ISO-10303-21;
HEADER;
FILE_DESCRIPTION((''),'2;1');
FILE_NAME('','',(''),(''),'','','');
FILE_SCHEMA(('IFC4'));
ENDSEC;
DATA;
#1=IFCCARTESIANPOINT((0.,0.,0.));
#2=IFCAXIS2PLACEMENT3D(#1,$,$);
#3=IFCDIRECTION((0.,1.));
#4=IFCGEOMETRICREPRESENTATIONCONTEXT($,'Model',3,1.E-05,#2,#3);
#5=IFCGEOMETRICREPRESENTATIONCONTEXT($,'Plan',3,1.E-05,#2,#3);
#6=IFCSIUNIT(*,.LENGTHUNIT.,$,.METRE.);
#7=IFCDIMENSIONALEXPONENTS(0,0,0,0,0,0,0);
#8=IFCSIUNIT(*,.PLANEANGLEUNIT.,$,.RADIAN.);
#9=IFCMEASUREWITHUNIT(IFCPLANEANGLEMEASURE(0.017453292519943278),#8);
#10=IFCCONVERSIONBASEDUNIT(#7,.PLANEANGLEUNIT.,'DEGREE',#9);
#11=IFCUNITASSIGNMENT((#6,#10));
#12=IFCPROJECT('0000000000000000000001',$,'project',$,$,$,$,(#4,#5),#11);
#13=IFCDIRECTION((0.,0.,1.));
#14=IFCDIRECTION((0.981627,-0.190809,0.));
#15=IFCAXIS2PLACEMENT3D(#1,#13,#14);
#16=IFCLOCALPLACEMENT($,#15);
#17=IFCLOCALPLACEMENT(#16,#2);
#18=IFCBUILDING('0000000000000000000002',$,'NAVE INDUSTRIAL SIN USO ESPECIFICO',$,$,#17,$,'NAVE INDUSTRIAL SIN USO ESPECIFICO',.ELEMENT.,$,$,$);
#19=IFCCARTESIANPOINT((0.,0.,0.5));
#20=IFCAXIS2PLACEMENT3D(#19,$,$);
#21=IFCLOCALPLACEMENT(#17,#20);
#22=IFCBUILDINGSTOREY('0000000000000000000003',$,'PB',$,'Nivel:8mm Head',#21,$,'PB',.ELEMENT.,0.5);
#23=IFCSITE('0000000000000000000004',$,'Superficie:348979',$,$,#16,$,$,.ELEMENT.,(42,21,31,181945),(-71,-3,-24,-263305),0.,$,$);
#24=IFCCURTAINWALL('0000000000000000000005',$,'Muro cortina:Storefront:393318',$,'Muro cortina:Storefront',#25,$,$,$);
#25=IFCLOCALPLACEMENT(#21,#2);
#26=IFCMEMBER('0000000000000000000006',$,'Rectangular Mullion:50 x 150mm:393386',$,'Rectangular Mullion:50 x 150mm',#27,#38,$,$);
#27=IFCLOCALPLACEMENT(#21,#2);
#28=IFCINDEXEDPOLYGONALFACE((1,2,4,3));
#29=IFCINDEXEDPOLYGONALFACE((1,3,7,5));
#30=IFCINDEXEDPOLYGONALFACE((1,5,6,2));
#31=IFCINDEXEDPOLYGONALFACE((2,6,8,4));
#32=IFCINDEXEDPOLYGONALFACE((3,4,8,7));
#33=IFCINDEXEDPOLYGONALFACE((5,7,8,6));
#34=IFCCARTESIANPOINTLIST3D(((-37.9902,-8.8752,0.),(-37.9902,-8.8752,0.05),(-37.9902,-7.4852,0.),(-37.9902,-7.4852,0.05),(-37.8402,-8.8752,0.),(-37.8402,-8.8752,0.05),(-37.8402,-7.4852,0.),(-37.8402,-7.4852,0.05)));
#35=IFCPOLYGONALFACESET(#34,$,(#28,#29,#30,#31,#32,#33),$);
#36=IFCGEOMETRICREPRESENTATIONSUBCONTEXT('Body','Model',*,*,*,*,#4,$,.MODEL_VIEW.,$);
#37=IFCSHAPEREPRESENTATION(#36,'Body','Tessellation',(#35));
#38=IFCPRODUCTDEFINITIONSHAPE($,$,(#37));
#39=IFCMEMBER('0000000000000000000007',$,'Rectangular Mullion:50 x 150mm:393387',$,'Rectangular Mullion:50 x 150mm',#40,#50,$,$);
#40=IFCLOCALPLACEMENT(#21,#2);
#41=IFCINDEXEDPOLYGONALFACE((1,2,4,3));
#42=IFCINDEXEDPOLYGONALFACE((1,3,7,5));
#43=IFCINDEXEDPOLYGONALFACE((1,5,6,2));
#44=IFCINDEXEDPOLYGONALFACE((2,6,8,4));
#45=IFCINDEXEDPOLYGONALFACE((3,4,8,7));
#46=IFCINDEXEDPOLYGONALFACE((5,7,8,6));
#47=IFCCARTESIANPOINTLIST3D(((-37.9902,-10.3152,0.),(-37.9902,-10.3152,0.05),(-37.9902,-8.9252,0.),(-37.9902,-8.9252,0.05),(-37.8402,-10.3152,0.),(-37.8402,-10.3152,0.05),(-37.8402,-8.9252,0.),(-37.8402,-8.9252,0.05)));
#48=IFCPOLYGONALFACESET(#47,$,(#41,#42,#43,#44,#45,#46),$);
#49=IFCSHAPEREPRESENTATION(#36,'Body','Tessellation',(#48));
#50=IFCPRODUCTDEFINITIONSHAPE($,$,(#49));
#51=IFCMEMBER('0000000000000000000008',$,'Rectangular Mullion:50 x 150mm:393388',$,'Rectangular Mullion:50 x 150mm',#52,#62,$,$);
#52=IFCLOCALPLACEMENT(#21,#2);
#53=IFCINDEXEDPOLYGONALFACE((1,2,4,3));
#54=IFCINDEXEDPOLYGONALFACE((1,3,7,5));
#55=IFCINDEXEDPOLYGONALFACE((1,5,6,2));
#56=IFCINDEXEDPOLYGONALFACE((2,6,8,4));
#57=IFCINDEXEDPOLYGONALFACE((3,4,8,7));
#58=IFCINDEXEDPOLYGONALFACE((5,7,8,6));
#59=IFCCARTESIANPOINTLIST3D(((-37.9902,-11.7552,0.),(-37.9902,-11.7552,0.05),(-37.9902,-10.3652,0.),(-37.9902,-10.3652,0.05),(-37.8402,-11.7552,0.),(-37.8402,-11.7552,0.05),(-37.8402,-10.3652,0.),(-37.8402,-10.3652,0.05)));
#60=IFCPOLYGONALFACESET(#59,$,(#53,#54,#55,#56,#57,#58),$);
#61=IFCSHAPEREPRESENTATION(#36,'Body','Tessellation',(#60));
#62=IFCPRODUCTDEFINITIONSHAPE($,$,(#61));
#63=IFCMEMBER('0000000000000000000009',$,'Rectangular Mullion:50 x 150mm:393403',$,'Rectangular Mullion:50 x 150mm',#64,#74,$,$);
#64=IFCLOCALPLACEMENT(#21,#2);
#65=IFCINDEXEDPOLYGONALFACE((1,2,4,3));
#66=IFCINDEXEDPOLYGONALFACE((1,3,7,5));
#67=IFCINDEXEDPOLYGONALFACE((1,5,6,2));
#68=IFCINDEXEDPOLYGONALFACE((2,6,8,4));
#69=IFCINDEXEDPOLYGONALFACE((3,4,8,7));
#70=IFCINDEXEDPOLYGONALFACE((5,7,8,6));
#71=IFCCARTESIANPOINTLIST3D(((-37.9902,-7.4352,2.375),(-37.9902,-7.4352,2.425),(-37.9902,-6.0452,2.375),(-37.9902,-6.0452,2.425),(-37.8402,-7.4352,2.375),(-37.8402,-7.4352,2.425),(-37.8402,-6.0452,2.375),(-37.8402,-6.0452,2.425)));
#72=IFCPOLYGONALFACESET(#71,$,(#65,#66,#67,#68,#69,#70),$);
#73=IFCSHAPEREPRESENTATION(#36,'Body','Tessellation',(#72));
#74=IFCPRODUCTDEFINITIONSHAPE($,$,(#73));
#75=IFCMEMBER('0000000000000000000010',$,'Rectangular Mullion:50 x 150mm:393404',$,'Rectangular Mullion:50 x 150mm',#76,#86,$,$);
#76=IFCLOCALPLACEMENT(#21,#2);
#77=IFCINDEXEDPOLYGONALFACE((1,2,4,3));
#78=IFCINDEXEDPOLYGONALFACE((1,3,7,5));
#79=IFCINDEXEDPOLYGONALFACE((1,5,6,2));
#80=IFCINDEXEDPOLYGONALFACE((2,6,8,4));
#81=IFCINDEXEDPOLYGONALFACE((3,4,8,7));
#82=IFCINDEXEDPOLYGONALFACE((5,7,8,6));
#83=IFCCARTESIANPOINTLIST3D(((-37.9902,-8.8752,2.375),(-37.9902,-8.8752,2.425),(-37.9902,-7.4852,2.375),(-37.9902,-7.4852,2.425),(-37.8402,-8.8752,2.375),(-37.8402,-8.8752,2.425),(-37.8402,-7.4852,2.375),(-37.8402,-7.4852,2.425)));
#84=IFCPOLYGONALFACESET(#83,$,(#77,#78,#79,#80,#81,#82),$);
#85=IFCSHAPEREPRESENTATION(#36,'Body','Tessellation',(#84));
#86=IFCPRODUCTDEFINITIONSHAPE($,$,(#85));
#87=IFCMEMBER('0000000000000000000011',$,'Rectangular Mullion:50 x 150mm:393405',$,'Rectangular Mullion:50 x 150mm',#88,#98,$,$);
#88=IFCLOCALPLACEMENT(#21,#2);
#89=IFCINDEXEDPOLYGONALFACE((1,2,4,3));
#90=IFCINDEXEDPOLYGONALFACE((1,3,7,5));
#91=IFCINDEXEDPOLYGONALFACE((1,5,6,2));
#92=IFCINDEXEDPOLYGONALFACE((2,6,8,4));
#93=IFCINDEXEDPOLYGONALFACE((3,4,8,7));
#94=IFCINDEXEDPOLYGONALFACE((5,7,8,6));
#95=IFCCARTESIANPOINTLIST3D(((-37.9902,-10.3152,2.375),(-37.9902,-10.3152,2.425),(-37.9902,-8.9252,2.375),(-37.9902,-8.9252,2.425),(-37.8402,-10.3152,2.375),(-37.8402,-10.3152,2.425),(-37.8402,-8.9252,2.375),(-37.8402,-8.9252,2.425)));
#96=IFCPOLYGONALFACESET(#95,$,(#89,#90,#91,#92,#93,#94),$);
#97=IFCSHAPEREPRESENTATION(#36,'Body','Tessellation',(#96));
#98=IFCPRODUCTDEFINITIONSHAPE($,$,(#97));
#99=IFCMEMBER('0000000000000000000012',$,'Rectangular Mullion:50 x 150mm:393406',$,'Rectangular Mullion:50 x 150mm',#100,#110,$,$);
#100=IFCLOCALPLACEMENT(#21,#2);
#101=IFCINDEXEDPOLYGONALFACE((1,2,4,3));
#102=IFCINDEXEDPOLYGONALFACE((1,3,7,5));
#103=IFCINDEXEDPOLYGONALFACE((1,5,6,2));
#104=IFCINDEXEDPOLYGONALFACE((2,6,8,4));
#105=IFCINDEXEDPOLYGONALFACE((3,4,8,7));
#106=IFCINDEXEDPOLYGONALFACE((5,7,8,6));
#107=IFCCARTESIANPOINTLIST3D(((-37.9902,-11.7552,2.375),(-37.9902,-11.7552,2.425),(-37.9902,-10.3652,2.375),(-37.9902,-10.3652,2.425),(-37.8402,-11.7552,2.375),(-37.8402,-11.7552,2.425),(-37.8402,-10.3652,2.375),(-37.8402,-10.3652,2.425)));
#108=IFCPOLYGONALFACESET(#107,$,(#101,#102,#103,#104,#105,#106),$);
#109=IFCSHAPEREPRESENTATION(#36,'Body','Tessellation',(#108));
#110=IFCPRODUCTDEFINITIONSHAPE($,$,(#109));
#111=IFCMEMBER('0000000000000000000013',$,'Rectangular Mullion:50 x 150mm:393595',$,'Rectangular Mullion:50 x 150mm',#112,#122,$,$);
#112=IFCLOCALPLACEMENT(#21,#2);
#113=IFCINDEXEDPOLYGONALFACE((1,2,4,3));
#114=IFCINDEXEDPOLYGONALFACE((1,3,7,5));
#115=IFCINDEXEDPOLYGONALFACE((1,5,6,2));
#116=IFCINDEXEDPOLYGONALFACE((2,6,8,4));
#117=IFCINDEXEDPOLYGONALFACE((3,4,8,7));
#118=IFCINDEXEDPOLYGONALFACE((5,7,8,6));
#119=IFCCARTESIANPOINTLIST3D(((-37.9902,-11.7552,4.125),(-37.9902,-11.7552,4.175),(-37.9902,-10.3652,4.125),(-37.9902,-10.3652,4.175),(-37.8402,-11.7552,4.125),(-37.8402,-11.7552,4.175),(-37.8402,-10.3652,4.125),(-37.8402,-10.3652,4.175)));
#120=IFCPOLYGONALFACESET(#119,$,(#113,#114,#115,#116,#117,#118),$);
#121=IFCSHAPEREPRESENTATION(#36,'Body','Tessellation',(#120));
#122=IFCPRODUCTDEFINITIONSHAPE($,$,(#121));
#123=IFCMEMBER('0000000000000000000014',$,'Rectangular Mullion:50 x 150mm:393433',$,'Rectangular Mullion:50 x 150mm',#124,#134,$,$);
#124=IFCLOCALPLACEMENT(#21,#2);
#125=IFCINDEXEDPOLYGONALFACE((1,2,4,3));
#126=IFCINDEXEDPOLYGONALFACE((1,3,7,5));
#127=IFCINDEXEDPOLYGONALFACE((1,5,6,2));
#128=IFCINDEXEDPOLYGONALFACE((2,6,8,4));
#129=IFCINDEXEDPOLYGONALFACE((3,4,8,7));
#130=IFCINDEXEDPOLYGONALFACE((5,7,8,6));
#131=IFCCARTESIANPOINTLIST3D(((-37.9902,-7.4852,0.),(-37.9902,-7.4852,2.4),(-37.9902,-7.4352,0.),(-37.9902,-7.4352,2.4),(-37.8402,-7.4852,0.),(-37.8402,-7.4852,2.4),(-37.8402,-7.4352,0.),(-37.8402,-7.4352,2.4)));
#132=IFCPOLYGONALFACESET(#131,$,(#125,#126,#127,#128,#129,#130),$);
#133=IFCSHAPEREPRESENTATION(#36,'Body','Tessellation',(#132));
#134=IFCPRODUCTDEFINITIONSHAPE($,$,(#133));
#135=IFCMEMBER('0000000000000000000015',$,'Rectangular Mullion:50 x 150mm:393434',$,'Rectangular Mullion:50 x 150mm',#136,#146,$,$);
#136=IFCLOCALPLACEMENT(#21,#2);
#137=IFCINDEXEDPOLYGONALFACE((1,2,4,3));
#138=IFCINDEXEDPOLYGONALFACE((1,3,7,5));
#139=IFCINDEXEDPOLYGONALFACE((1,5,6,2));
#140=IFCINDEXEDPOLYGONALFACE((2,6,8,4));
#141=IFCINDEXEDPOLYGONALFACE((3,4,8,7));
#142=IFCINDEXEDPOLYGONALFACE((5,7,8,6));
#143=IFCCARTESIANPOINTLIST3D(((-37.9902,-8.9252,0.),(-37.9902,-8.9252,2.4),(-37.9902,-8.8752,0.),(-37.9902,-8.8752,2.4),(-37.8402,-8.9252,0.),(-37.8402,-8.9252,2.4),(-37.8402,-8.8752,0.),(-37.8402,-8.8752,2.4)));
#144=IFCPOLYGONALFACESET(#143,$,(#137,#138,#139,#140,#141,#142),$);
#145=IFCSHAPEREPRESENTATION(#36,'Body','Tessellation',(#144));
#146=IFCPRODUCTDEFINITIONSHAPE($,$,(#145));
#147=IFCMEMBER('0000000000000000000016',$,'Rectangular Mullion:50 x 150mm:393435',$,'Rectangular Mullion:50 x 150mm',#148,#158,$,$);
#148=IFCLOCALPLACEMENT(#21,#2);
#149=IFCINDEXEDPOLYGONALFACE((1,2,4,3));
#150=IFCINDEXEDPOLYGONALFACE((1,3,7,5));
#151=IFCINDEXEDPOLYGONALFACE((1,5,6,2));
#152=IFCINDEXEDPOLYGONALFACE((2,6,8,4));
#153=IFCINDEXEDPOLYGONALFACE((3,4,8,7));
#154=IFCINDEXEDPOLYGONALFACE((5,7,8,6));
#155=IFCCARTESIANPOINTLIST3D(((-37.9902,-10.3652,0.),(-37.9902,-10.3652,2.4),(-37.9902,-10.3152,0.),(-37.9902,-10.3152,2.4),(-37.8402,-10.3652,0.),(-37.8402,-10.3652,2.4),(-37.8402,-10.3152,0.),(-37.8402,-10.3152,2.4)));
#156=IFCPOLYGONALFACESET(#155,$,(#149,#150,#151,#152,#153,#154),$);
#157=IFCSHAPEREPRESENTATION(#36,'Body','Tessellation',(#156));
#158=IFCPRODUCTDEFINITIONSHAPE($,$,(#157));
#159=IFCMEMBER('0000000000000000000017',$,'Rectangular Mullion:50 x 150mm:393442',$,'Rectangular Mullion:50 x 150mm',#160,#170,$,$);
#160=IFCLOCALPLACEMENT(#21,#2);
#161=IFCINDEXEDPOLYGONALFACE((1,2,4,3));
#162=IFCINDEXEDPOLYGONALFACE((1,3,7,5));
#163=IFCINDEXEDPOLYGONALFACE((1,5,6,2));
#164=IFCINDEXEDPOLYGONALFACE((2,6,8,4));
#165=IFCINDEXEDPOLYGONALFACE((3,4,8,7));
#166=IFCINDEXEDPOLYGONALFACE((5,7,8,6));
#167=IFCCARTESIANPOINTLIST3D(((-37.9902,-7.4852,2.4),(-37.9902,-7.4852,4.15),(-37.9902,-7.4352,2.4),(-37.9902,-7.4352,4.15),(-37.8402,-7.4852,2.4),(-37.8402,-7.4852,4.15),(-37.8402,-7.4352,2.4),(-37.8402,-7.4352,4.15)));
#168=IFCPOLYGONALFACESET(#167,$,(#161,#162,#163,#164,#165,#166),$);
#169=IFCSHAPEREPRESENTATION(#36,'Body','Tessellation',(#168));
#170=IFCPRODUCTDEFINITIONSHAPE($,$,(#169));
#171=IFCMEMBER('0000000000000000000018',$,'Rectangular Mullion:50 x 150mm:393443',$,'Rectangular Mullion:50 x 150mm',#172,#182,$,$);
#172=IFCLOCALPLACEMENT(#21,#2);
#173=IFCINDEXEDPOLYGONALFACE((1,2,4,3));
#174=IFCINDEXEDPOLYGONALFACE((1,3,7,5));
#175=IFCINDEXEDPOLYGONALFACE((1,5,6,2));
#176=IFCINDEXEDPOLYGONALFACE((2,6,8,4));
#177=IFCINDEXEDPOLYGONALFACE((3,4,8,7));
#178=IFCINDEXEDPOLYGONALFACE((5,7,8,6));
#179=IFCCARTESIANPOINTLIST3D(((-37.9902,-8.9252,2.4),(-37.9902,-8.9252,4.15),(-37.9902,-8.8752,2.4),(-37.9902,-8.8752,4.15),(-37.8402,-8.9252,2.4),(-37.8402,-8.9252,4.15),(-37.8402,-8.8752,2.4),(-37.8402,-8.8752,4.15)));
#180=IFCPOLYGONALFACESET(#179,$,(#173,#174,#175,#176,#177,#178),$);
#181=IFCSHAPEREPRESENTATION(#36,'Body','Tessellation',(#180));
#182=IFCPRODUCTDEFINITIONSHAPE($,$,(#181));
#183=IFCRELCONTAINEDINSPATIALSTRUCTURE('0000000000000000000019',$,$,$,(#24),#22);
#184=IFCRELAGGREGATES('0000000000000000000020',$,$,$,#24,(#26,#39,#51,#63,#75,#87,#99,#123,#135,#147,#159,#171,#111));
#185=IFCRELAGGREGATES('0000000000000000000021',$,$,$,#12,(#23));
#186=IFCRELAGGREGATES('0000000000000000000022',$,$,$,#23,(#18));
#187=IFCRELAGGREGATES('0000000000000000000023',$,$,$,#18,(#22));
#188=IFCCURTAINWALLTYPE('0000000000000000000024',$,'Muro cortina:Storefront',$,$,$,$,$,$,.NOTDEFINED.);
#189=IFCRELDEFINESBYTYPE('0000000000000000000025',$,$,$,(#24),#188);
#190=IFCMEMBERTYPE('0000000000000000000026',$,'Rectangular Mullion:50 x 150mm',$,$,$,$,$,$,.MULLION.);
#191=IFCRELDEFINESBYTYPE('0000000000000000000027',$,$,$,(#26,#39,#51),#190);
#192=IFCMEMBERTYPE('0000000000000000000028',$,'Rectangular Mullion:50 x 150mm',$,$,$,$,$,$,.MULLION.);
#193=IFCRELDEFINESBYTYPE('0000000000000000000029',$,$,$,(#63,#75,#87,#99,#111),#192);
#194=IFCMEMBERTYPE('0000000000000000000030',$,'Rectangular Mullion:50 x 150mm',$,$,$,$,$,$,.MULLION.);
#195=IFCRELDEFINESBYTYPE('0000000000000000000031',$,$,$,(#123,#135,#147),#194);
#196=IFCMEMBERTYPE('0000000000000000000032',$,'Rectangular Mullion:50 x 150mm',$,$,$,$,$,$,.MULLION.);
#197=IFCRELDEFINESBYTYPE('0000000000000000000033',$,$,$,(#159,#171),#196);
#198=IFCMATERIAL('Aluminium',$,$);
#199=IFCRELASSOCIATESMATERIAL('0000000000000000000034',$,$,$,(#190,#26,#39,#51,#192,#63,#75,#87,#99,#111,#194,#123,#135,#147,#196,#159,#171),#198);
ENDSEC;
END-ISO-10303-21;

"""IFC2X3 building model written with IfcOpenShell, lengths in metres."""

from ifc_helpers import new_model, entity, si_unit, converted_unit, direction, frame, origin, origin_2d_with_axis, place, context, subcontext, project, spatial, rectangle, extrude, source, transform, mapped, material, type_object, type_shapes, element, aggregate, save


model = new_model("IFC2X3")

# Units and contexts
model_context = context("Model", 3, precision=1e-05, world=origin(), true_north=direction((0.0, 1.0)))
plan_context = context("Plan", 3, precision=1e-05, world=origin(), true_north=direction((0.0, 1.0)))
body_context = subcontext(model_context, "Body", "Model", "MODEL_VIEW")
ifc_project = project(units=[si_unit("LENGTHUNIT", "METRE"), converted_unit("PLANEANGLEUNIT", "DEGREE", entity("IfcPlaneAngleMeasure", 0.017453292519943278), si_unit("PLANEANGLEUNIT", "RADIAN"), dimensions=[0, 0, 0, 0, 0, 0, 0])], contexts=[model_context, plan_context])

# Site, building, storey
site_placement = place(None, frame((0.0, 0.0, 0.0), z_axis=(0.0, 0.0, 1.0), x_axis=(0.981627, -0.190809, 0.0)))
site = spatial("IfcSite", under=ifc_project, at=site_placement, Name="Superficie:348979", CompositionType="ELEMENT", RefLatitude=(42, 21, 31, 181945), RefLongitude=(-71, -3, -24, -263305), RefElevation=0.0)
building_placement = place(site_placement, origin())
building = spatial("IfcBuilding", under=site, at=building_placement, Name="NAVE INDUSTRIAL SIN USO ESPECIFICO", LongName="NAVE INDUSTRIAL SIN USO ESPECIFICO", CompositionType="ELEMENT")
storey_placement = place(building_placement, frame((0.0, 0.0, 0.5)))
storey = spatial("IfcBuildingStorey", under=building, at=storey_placement, Name="PB", ObjectType="Nivel:8mm Head", LongName="PB", CompositionType="ELEMENT", Elevation=0.5)

# Curtain wall, members
curtain_wall_type = type_object("IfcCurtainWallType", Name="Muro cortina:Storefront", PredefinedType="NOTDEFINED")
curtain_wall_placement = place(storey_placement, frame((0.0, 0.0, -0.5)))
curtain_wall = element("IfcCurtainWall", 1, at=curtain_wall_placement, inside=storey, type_object=curtain_wall_type, Name="Muro cortina:Storefront:393318", ObjectType="Muro cortina:Storefront")
ifc_material_1 = material(Name="Aluminium")
member_type_1 = type_object("IfcMemberType", Name="Rectangular Mullion:50 x 150mm", PredefinedType="MULLION", material=ifc_material_1)
shared_shape_1 = source(origin(), body_context, "Body", "SweptSolid", [
    extrude(rectangle(XDim=0.05, YDim=0.15, at=origin_2d_with_axis()), frame((-0.025, 0.0, -1.39), z_axis=(0.0, 0.0, 1.0), x_axis=(-1.0, 0.0, 0.0)), (0.0, 0.0, 1.0), 1.39),
])
type_shapes(member_type_1, [shared_shape_1])
member_1_placement = place(curtain_wall_placement, frame((-37.9152, -7.4852, 0.5), z_axis=(0.0, 1.0, 0.0), x_axis=(0.0, 0.0, -1.0)))
member_1 = element("IfcMember", 2, at=member_1_placement, type_object=member_type_1, material=ifc_material_1, Name="Rectangular Mullion:50 x 150mm:393386", ObjectType="Rectangular Mullion:50 x 150mm", context=body_context, shape_type="MappedRepresentation", body=[
    mapped(shared_shape_1, transform((0.0, 0.0, 0.0), scale=1.0)),
])
member_2_placement = place(curtain_wall_placement, frame((-37.9152, -8.9252, 0.5), z_axis=(0.0, 1.0, 0.0), x_axis=(0.0, 0.0, -1.0)))
member_2 = element("IfcMember", 3, at=member_2_placement, type_object=member_type_1, material=ifc_material_1, Name="Rectangular Mullion:50 x 150mm:393387", ObjectType="Rectangular Mullion:50 x 150mm", context=body_context, shape_type="MappedRepresentation", body=[
    mapped(shared_shape_1, transform((0.0, 0.0, 0.0), scale=1.0)),
])
member_3_placement = place(curtain_wall_placement, frame((-37.9152, -10.3652, 0.5), z_axis=(0.0, 1.0, 0.0), x_axis=(0.0, 0.0, -1.0)))
member_3 = element("IfcMember", 4, at=member_3_placement, type_object=member_type_1, material=ifc_material_1, Name="Rectangular Mullion:50 x 150mm:393388", ObjectType="Rectangular Mullion:50 x 150mm", context=body_context, shape_type="MappedRepresentation", body=[
    mapped(shared_shape_1, transform((0.0, 0.0, 0.0), scale=1.0)),
])
member_type_2 = type_object("IfcMemberType", Name="Rectangular Mullion:50 x 150mm", PredefinedType="MULLION", material=ifc_material_1)
shared_shape_2 = source(origin(), body_context, "Body", "SweptSolid", [
    extrude(rectangle(XDim=0.05, YDim=0.15, at=origin_2d_with_axis()), frame((0.0, 0.0, -1.39), z_axis=(0.0, 0.0, 1.0), x_axis=(-1.0, 0.0, 0.0)), (0.0, 0.0, 1.0), 1.39),
])
type_shapes(member_type_2, [shared_shape_2])
member_4_placement = place(curtain_wall_placement, frame((-37.9152, -7.4352, 2.9), z_axis=(0.0, -1.0, 0.0), x_axis=(0.0, 0.0, 1.0)))
member_4 = element("IfcMember", 5, at=member_4_placement, type_object=member_type_2, material=ifc_material_1, Name="Rectangular Mullion:50 x 150mm:393403", ObjectType="Rectangular Mullion:50 x 150mm", context=body_context, shape_type="MappedRepresentation", body=[
    mapped(shared_shape_2, transform((0.0, 0.0, 0.0), scale=1.0)),
])
member_5_placement = place(curtain_wall_placement, frame((-37.9152, -8.8752, 2.9), z_axis=(0.0, -1.0, 0.0), x_axis=(0.0, 0.0, 1.0)))
member_5 = element("IfcMember", 6, at=member_5_placement, type_object=member_type_2, material=ifc_material_1, Name="Rectangular Mullion:50 x 150mm:393404", ObjectType="Rectangular Mullion:50 x 150mm", context=body_context, shape_type="MappedRepresentation", body=[
    mapped(shared_shape_2, transform((0.0, 0.0, 0.0), scale=1.0)),
])
member_6_placement = place(curtain_wall_placement, frame((-37.9152, -10.3152, 2.9), z_axis=(0.0, -1.0, 0.0), x_axis=(0.0, 0.0, 1.0)))
member_6 = element("IfcMember", 7, at=member_6_placement, type_object=member_type_2, material=ifc_material_1, Name="Rectangular Mullion:50 x 150mm:393405", ObjectType="Rectangular Mullion:50 x 150mm", context=body_context, shape_type="MappedRepresentation", body=[
    mapped(shared_shape_2, transform((0.0, 0.0, 0.0), scale=1.0)),
])
member_7_placement = place(curtain_wall_placement, frame((-37.9152, -11.7552, 2.9), z_axis=(0.0, -1.0, 0.0), x_axis=(0.0, 0.0, 1.0)))
member_7 = element("IfcMember", 8, at=member_7_placement, type_object=member_type_2, material=ifc_material_1, Name="Rectangular Mullion:50 x 150mm:393406", ObjectType="Rectangular Mullion:50 x 150mm", context=body_context, shape_type="MappedRepresentation", body=[
    mapped(shared_shape_2, transform((0.0, 0.0, 0.0), scale=1.0)),
])
member_8_placement = place(curtain_wall_placement, frame((-37.9152, -11.7552, 4.65), z_axis=(0.0, -1.0, 0.0), x_axis=(0.0, 0.0, 1.0)))
member_8 = element("IfcMember", 9, at=member_8_placement, type_object=member_type_2, material=ifc_material_1, Name="Rectangular Mullion:50 x 150mm:393595", ObjectType="Rectangular Mullion:50 x 150mm", context=body_context, shape_type="MappedRepresentation", body=[
    mapped(shared_shape_2, transform((0.0, 0.0, 0.0), scale=1.0)),
])
member_type_3 = type_object("IfcMemberType", Name="Rectangular Mullion:50 x 150mm", PredefinedType="MULLION", material=ifc_material_1)
shared_shape_3 = source(origin(), body_context, "Body", "SweptSolid", [
    extrude(rectangle(XDim=0.05, YDim=0.15, at=origin_2d_with_axis()), frame((0.0, 0.0, -2.4), z_axis=(0.0, 0.0, 1.0), x_axis=(-1.0, 0.0, 0.0)), (0.0, 0.0, 1.0), 2.4),
])
type_shapes(member_type_3, [shared_shape_3])
member_9_placement = place(curtain_wall_placement, frame((-37.9152, -7.4602, 0.5), z_axis=(0.0, 0.0, -1.0), x_axis=(0.0, -1.0, 0.0)))
member_9 = element("IfcMember", 10, at=member_9_placement, type_object=member_type_3, material=ifc_material_1, Name="Rectangular Mullion:50 x 150mm:393433", ObjectType="Rectangular Mullion:50 x 150mm", context=body_context, shape_type="MappedRepresentation", body=[
    mapped(shared_shape_3, transform((0.0, 0.0, 0.0), scale=1.0)),
])
member_10_placement = place(curtain_wall_placement, frame((-37.9152, -8.9002, 0.5), z_axis=(0.0, 0.0, -1.0), x_axis=(0.0, -1.0, 0.0)))
member_10 = element("IfcMember", 11, at=member_10_placement, type_object=member_type_3, material=ifc_material_1, Name="Rectangular Mullion:50 x 150mm:393434", ObjectType="Rectangular Mullion:50 x 150mm", context=body_context, shape_type="MappedRepresentation", body=[
    mapped(shared_shape_3, transform((0.0, 0.0, 0.0), scale=1.0)),
])
member_11_placement = place(curtain_wall_placement, frame((-37.9152, -10.3402, 0.5), z_axis=(0.0, 0.0, -1.0), x_axis=(0.0, -1.0, 0.0)))
member_11 = element("IfcMember", 12, at=member_11_placement, type_object=member_type_3, material=ifc_material_1, Name="Rectangular Mullion:50 x 150mm:393435", ObjectType="Rectangular Mullion:50 x 150mm", context=body_context, shape_type="MappedRepresentation", body=[
    mapped(shared_shape_3, transform((0.0, 0.0, 0.0), scale=1.0)),
])
member_type_4 = type_object("IfcMemberType", Name="Rectangular Mullion:50 x 150mm", PredefinedType="MULLION", material=ifc_material_1)
shared_shape_4 = source(origin(), body_context, "Body", "SweptSolid", [
    extrude(rectangle(XDim=0.05, YDim=0.15, at=origin_2d_with_axis()), frame((0.0, 0.0, -1.75), z_axis=(0.0, 0.0, 1.0), x_axis=(-1.0, 0.0, 0.0)), (0.0, 0.0, 1.0), 1.75),
])
type_shapes(member_type_4, [shared_shape_4])
member_12_placement = place(curtain_wall_placement, frame((-37.9152, -7.4602, 2.9), z_axis=(0.0, 0.0, -1.0), x_axis=(0.0, -1.0, 0.0)))
member_12 = element("IfcMember", 13, at=member_12_placement, type_object=member_type_4, material=ifc_material_1, Name="Rectangular Mullion:50 x 150mm:393442", ObjectType="Rectangular Mullion:50 x 150mm", context=body_context, shape_type="MappedRepresentation", body=[
    mapped(shared_shape_4, transform((0.0, 0.0, 0.0), scale=1.0)),
])
member_13_placement = place(curtain_wall_placement, frame((-37.9152, -8.9002, 2.9), z_axis=(0.0, 0.0, -1.0), x_axis=(0.0, -1.0, 0.0)))
member_13 = element("IfcMember", 14, at=member_13_placement, type_object=member_type_4, material=ifc_material_1, Name="Rectangular Mullion:50 x 150mm:393443", ObjectType="Rectangular Mullion:50 x 150mm", context=body_context, shape_type="MappedRepresentation", body=[
    mapped(shared_shape_4, transform((0.0, 0.0, 0.0), scale=1.0)),
])
aggregate(curtain_wall, [member_1, member_2, member_3, member_4, member_5, member_6, member_7, member_9, member_10, member_11, member_12, member_13, member_8])

save(model, "model.ifc")
